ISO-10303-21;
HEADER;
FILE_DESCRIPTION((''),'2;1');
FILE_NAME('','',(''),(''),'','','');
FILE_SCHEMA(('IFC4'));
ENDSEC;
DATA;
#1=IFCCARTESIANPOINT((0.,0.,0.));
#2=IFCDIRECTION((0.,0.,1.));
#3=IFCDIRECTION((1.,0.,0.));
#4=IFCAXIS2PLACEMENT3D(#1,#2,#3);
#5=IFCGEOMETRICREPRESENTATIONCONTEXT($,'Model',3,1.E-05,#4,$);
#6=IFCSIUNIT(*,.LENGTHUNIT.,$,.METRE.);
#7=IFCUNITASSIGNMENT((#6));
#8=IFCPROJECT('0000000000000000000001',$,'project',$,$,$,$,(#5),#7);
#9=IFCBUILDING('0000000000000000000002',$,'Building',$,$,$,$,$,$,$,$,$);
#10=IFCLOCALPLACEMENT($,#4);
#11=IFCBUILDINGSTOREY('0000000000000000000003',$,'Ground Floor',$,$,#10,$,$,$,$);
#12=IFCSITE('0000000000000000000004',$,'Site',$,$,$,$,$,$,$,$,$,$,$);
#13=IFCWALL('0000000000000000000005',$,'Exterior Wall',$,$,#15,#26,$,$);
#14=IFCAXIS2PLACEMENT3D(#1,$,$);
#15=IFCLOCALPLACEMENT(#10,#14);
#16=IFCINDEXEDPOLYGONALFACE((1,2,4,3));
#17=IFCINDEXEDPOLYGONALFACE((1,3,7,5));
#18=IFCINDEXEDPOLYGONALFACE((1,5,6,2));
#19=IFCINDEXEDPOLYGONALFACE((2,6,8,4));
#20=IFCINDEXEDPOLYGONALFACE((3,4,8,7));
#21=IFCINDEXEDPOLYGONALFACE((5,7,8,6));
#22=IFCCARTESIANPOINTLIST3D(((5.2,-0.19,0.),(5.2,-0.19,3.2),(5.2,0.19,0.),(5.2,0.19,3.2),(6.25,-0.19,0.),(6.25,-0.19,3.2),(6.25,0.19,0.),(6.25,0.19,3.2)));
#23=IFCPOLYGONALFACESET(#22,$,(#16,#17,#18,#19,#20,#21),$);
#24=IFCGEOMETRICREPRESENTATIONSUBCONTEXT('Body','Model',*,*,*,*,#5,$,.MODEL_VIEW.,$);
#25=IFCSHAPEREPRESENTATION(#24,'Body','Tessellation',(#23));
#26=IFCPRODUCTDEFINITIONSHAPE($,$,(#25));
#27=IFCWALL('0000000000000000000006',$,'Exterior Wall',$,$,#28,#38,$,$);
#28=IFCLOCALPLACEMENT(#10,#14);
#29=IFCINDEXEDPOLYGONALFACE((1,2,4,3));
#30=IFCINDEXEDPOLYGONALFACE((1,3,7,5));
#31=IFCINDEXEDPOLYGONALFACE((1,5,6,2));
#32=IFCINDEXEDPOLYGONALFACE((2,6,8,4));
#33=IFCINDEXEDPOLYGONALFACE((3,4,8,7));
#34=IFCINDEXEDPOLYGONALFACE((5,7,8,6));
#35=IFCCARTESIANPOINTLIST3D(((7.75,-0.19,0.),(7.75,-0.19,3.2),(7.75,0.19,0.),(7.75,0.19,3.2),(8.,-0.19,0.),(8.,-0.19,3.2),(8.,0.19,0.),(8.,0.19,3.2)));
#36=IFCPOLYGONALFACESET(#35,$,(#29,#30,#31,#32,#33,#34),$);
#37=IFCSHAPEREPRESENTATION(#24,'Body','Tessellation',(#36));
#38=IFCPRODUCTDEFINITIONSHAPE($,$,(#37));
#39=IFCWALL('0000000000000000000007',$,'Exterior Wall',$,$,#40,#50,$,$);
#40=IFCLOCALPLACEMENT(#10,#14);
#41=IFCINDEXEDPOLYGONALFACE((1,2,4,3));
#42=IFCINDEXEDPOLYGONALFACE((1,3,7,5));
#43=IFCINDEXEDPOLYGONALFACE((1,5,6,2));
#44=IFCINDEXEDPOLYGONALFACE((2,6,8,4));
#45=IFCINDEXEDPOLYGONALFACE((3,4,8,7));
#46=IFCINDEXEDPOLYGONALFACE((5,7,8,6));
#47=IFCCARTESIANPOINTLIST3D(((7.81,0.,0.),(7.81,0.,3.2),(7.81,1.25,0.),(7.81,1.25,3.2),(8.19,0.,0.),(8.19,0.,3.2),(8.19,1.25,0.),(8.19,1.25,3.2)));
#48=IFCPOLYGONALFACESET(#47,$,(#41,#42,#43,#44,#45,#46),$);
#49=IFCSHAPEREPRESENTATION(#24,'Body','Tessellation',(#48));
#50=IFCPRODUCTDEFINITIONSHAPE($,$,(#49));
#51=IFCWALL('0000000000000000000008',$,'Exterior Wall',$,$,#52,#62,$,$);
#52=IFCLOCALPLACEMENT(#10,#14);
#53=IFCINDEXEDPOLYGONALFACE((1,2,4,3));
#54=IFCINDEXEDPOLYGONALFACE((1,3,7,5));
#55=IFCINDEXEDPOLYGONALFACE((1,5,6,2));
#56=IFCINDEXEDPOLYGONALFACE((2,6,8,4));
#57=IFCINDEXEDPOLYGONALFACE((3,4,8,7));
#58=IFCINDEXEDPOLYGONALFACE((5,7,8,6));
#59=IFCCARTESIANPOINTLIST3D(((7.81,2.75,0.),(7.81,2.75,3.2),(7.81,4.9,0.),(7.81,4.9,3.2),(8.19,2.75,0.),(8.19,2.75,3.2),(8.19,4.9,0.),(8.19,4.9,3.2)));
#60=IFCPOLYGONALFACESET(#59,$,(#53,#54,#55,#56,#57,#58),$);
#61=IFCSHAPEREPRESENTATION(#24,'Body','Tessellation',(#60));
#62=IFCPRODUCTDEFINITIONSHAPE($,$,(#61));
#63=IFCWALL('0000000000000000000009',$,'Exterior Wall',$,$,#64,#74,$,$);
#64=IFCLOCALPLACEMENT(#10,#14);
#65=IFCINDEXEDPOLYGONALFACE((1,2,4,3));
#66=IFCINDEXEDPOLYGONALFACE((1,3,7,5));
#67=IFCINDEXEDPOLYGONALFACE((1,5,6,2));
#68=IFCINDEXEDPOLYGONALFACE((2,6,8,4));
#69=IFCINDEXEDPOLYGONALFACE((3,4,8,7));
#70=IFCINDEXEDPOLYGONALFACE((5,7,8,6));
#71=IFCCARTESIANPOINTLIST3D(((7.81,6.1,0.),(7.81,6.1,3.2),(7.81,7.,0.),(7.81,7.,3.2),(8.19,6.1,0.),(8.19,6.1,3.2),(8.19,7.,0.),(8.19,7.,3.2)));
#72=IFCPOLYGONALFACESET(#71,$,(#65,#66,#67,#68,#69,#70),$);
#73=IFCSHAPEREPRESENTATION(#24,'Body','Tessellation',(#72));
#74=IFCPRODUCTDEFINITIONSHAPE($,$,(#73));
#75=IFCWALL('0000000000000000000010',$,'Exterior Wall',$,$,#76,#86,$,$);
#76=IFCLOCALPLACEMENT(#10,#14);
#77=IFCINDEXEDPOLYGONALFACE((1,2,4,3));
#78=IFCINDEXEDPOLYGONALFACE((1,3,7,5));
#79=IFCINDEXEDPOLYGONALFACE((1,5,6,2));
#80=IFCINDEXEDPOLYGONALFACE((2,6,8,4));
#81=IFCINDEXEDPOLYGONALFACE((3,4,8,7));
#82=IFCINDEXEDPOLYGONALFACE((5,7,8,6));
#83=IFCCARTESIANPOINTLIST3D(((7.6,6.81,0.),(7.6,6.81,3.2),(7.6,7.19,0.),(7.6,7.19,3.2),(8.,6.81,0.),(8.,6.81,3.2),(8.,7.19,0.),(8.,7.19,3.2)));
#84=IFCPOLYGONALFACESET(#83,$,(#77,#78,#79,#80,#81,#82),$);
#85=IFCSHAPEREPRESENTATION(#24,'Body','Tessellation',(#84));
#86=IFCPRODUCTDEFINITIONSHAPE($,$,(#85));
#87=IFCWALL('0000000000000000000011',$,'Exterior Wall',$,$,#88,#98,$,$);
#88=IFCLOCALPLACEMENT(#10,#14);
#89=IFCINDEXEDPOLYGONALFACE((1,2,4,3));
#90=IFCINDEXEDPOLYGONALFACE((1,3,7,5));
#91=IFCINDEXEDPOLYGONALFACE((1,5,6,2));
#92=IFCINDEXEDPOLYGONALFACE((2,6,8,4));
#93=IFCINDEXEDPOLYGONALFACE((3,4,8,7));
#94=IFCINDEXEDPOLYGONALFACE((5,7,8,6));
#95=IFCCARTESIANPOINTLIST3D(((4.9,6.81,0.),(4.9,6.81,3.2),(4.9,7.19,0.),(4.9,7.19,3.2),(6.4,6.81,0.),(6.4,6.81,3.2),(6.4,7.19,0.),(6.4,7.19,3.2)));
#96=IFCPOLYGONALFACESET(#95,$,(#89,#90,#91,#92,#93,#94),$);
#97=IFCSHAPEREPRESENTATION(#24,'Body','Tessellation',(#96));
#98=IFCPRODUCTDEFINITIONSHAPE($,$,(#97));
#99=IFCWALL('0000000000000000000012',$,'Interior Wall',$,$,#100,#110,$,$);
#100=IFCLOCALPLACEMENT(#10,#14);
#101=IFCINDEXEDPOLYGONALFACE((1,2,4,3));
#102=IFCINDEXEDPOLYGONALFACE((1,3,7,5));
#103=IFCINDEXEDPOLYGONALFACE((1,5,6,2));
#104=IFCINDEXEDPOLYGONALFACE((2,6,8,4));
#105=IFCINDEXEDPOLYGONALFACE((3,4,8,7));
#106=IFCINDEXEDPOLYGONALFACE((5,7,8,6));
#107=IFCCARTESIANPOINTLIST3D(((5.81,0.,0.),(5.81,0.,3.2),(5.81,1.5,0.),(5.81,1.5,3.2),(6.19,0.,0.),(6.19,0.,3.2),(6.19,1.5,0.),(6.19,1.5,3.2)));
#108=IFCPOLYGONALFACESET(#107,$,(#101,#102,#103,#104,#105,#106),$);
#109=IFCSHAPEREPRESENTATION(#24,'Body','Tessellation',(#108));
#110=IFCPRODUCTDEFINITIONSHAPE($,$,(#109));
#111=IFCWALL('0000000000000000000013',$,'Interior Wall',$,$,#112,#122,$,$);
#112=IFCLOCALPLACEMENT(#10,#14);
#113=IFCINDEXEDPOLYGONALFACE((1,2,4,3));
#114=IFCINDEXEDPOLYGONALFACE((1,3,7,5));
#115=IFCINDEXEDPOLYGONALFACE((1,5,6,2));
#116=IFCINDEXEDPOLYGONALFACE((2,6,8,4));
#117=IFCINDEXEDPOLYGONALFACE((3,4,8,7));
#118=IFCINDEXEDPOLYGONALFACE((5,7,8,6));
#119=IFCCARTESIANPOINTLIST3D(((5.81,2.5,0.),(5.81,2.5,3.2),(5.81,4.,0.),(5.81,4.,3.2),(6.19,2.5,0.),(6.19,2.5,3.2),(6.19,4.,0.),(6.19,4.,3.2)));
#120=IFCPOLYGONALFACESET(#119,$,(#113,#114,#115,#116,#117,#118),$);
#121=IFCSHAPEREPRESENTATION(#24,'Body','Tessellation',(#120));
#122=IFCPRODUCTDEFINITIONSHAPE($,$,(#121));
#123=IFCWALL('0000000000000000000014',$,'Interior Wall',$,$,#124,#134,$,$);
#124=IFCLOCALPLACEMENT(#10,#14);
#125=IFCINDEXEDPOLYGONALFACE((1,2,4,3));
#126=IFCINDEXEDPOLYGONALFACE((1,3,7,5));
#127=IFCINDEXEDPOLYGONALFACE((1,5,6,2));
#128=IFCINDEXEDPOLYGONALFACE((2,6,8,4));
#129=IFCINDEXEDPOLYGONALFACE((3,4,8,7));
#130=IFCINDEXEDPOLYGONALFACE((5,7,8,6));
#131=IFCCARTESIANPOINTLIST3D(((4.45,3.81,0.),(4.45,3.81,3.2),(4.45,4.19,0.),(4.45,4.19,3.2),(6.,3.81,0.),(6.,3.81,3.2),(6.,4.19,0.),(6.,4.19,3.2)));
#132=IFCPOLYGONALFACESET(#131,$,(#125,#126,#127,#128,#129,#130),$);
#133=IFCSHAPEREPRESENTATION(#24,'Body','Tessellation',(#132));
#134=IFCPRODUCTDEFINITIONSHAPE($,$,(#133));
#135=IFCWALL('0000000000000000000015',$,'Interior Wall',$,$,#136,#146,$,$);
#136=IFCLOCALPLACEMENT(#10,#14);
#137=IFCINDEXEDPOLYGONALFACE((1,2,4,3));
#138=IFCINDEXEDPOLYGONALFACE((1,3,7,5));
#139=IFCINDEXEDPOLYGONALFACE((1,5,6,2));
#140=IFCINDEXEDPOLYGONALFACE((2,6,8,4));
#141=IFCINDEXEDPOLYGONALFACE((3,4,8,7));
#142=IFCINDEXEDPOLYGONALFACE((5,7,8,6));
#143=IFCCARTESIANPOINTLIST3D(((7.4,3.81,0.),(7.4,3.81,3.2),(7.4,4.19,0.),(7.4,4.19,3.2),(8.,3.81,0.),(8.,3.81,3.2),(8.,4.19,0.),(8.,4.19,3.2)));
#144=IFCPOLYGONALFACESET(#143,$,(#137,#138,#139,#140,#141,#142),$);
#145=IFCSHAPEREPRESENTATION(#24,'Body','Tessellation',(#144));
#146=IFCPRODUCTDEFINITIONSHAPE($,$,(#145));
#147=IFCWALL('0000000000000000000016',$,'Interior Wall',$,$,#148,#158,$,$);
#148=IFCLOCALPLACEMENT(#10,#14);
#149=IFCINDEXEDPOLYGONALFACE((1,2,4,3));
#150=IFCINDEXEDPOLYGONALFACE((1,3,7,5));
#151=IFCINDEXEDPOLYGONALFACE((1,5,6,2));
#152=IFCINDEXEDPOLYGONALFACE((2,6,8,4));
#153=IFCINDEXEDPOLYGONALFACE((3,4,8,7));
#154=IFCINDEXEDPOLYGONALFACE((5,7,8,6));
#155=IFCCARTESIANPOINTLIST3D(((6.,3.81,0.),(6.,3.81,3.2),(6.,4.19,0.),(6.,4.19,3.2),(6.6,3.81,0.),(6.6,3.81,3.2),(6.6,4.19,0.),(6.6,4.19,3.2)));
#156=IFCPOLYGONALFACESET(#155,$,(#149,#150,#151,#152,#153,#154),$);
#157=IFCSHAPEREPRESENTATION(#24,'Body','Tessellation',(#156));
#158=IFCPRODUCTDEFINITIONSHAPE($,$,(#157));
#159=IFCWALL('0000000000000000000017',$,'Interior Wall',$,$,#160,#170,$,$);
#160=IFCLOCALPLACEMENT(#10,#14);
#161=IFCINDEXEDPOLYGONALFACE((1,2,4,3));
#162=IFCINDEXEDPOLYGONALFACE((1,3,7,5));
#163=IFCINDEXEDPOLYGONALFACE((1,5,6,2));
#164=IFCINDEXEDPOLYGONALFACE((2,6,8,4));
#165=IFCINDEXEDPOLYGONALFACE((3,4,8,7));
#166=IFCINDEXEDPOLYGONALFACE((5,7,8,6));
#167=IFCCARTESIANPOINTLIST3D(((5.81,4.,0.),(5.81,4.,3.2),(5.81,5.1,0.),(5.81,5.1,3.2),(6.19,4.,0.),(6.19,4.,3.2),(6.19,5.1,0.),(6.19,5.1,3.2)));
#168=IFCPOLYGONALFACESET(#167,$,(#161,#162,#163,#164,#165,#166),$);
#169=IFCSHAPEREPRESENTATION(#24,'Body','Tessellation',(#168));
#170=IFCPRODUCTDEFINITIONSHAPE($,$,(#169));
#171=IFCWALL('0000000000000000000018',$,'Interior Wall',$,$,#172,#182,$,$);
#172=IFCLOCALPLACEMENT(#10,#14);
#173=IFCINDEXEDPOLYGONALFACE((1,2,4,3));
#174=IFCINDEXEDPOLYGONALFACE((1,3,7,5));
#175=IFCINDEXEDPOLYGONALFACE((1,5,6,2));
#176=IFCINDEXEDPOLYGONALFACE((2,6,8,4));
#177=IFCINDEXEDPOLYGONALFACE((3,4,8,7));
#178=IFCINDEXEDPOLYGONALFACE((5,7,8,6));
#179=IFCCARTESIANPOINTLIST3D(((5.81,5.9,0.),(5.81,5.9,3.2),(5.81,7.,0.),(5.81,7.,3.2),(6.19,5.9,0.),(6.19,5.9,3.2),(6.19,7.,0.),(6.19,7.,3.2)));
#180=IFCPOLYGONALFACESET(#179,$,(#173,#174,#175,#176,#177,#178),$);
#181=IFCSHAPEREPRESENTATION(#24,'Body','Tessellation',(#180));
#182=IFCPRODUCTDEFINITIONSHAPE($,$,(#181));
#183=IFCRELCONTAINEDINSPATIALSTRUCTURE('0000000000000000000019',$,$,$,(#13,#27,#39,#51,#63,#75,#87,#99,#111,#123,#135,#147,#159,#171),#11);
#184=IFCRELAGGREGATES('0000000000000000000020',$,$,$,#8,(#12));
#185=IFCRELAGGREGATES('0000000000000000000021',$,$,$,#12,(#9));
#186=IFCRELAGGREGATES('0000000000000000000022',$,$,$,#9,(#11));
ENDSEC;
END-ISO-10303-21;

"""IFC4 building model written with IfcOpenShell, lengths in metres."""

from ifc_helpers import new_model, si_unit, frame, origin_with_axes, place, context, subcontext, project, spatial, indexed_curve, outline, extrude, element, save


model = new_model("IFC4")

# Units and contexts
model_context = context("Model", 3, precision=1e-05, world=origin_with_axes())
body_context = subcontext(model_context, "Body", "Model", "MODEL_VIEW")
ifc_project = project(units=[si_unit("LENGTHUNIT", "METRE")], contexts=[model_context])

# Site, building, storey
site = spatial("IfcSite", under=ifc_project, Name="Site")
building = spatial("IfcBuilding", under=site, Name="Building")
storey_placement = place(None, origin_with_axes())
storey = spatial("IfcBuildingStorey", under=building, at=storey_placement, Name="Ground Floor")

# Walls
wall_1_placement = place(storey_placement, frame((5.2, 0.0, 0.0), z_axis=(0.0, 0.0, 1.0), x_axis=(1.0, 0.0, 0.0)))
element("IfcWall", 1, at=wall_1_placement, inside=storey, Name="Exterior Wall", context=body_context, shape_type="SweptSolid", body=[
    extrude(outline(indexed_curve([(0.0, 0.0), (0.0, 0.38), (1.05, 0.38), (1.05, 0.0), (0.0, 0.0)], self_intersect=False)), frame((0.0, -0.19, 0.0), z_axis=(0.0, 0.0, 1.0), x_axis=(1.0, 0.0, 0.0)), (0.0, 0.0, 1.0), 3.2),
])
wall_2_placement = place(storey_placement, frame((7.75, 0.0, 0.0), z_axis=(0.0, 0.0, 1.0), x_axis=(1.0, 0.0, 0.0)))
element("IfcWall", 2, at=wall_2_placement, inside=storey, Name="Exterior Wall", context=body_context, shape_type="SweptSolid", body=[
    extrude(outline(indexed_curve([(0.0, 0.0), (0.0, 0.38), (0.25, 0.38), (0.25, 0.0), (0.0, 0.0)], self_intersect=False)), frame((0.0, -0.19, 0.0), z_axis=(0.0, 0.0, 1.0), x_axis=(1.0, 0.0, 0.0)), (0.0, 0.0, 1.0), 3.2),
])
wall_3_placement = place(storey_placement, frame((8.0, 0.0, 0.0), z_axis=(0.0, 0.0, 1.0), x_axis=(0.0, 1.0, 0.0)))
element("IfcWall", 3, at=wall_3_placement, inside=storey, Name="Exterior Wall", context=body_context, shape_type="SweptSolid", body=[
    extrude(outline(indexed_curve([(0.0, 0.0), (0.0, 0.38), (1.25, 0.38), (1.25, 0.0), (0.0, 0.0)], self_intersect=False)), frame((0.0, -0.19, 0.0), z_axis=(0.0, 0.0, 1.0), x_axis=(1.0, 0.0, 0.0)), (0.0, 0.0, 1.0), 3.2),
])
wall_4_placement = place(storey_placement, frame((8.0, 2.75, 0.0), z_axis=(0.0, 0.0, 1.0), x_axis=(0.0, 1.0, 0.0)))
element("IfcWall", 4, at=wall_4_placement, inside=storey, Name="Exterior Wall", context=body_context, shape_type="SweptSolid", body=[
    extrude(outline(indexed_curve([(0.0, 0.0), (0.0, 0.38), (2.15, 0.38), (2.15, 0.0), (0.0, 0.0)], self_intersect=False)), frame((0.0, -0.19, 0.0), z_axis=(0.0, 0.0, 1.0), x_axis=(1.0, 0.0, 0.0)), (0.0, 0.0, 1.0), 3.2),
])
wall_5_placement = place(storey_placement, frame((8.0, 6.1, 0.0), z_axis=(0.0, 0.0, 1.0), x_axis=(0.0, 1.0, 0.0)))
element("IfcWall", 5, at=wall_5_placement, inside=storey, Name="Exterior Wall", context=body_context, shape_type="SweptSolid", body=[
    extrude(outline(indexed_curve([(0.0, 0.0), (0.0, 0.38), (0.9, 0.38), (0.9, 0.0), (0.0, 0.0)], self_intersect=False)), frame((0.0, -0.19, 0.0), z_axis=(0.0, 0.0, 1.0), x_axis=(1.0, 0.0, 0.0)), (0.0, 0.0, 1.0), 3.2),
])
wall_6_placement = place(storey_placement, frame((8.0, 7.0, 0.0), z_axis=(0.0, 0.0, 1.0), x_axis=(-1.0, 0.0, 0.0)))
element("IfcWall", 6, at=wall_6_placement, inside=storey, Name="Exterior Wall", context=body_context, shape_type="SweptSolid", body=[
    extrude(outline(indexed_curve([(0.0, 0.0), (0.0, 0.38), (0.4, 0.38), (0.4, 0.0), (0.0, 0.0)], self_intersect=False)), frame((0.0, -0.19, 0.0), z_axis=(0.0, 0.0, 1.0), x_axis=(1.0, 0.0, 0.0)), (0.0, 0.0, 1.0), 3.2),
])
for number, where, z_axis, x_axis, name in (
    (7, (6.4, 7.0, 0.0), (0.0, 0.0, 1.0), (-1.0, 0.0, 0.0), "Exterior Wall"),
    (8, (6.0, 0.0, 0.0), (0.0, 0.0, 1.0), (0.0, 1.0, 0.0), "Interior Wall"),
    (9, (6.0, 2.5, 0.0), (0.0, 0.0, 1.0), (0.0, 1.0, 0.0), "Interior Wall"),
):
    element("IfcWall", number, at=place(storey_placement, frame(where, z_axis=z_axis, x_axis=x_axis)), inside=storey, Name=name, context=body_context, shape_type="SweptSolid", body=[
        extrude(outline(indexed_curve([(0.0, 0.0), (0.0, 0.38), (1.5, 0.38), (1.5, 0.0), (0.0, 0.0)], self_intersect=False)), frame((0.0, -0.19, 0.0), z_axis=(0.0, 0.0, 1.0), x_axis=(1.0, 0.0, 0.0)), (0.0, 0.0, 1.0), 3.2),
    ])
wall_7_placement = place(storey_placement, frame((6.0, 4.0, 0.0), z_axis=(0.0, 0.0, 1.0), x_axis=(-1.0, 0.0, 0.0)))
element("IfcWall", 10, at=wall_7_placement, inside=storey, Name="Interior Wall", context=body_context, shape_type="SweptSolid", body=[
    extrude(outline(indexed_curve([(0.0, 0.0), (0.0, 0.38), (1.55, 0.38), (1.55, 0.0), (0.0, 0.0)], self_intersect=False)), frame((0.0, -0.19, 0.0), z_axis=(0.0, 0.0, 1.0), x_axis=(1.0, 0.0, 0.0)), (0.0, 0.0, 1.0), 3.2),
])
for number, where, z_axis, x_axis, name in (
    (11, (8.0, 4.0, 0.0), (0.0, 0.0, 1.0), (-1.0, 0.0, 0.0), "Interior Wall"),
    (12, (6.6, 4.0, 0.0), (0.0, 0.0, 1.0), (-1.0, 0.0, 0.0), "Interior Wall"),
):
    element("IfcWall", number, at=place(storey_placement, frame(where, z_axis=z_axis, x_axis=x_axis)), inside=storey, Name=name, context=body_context, shape_type="SweptSolid", body=[
        extrude(outline(indexed_curve([(0.0, 0.0), (0.0, 0.38), (0.6, 0.38), (0.6, 0.0), (0.0, 0.0)], self_intersect=False)), frame((0.0, -0.19, 0.0), z_axis=(0.0, 0.0, 1.0), x_axis=(1.0, 0.0, 0.0)), (0.0, 0.0, 1.0), 3.2),
    ])
for number, where, z_axis, x_axis, name in (
    (13, (6.0, 4.0, 0.0), (0.0, 0.0, 1.0), (0.0, 1.0, 0.0), "Interior Wall"),
    (14, (6.0, 5.9, 0.0), (0.0, 0.0, 1.0), (0.0, 1.0, 0.0), "Interior Wall"),
):
    element("IfcWall", number, at=place(storey_placement, frame(where, z_axis=z_axis, x_axis=x_axis)), inside=storey, Name=name, context=body_context, shape_type="SweptSolid", body=[
        extrude(outline(indexed_curve([(0.0, 0.0), (0.0, 0.38), (1.1, 0.38), (1.1, 0.0), (0.0, 0.0)], self_intersect=False)), frame((0.0, -0.19, 0.0), z_axis=(0.0, 0.0, 1.0), x_axis=(1.0, 0.0, 0.0)), (0.0, 0.0, 1.0), 3.2),
    ])

save(model, "model.ifc")
